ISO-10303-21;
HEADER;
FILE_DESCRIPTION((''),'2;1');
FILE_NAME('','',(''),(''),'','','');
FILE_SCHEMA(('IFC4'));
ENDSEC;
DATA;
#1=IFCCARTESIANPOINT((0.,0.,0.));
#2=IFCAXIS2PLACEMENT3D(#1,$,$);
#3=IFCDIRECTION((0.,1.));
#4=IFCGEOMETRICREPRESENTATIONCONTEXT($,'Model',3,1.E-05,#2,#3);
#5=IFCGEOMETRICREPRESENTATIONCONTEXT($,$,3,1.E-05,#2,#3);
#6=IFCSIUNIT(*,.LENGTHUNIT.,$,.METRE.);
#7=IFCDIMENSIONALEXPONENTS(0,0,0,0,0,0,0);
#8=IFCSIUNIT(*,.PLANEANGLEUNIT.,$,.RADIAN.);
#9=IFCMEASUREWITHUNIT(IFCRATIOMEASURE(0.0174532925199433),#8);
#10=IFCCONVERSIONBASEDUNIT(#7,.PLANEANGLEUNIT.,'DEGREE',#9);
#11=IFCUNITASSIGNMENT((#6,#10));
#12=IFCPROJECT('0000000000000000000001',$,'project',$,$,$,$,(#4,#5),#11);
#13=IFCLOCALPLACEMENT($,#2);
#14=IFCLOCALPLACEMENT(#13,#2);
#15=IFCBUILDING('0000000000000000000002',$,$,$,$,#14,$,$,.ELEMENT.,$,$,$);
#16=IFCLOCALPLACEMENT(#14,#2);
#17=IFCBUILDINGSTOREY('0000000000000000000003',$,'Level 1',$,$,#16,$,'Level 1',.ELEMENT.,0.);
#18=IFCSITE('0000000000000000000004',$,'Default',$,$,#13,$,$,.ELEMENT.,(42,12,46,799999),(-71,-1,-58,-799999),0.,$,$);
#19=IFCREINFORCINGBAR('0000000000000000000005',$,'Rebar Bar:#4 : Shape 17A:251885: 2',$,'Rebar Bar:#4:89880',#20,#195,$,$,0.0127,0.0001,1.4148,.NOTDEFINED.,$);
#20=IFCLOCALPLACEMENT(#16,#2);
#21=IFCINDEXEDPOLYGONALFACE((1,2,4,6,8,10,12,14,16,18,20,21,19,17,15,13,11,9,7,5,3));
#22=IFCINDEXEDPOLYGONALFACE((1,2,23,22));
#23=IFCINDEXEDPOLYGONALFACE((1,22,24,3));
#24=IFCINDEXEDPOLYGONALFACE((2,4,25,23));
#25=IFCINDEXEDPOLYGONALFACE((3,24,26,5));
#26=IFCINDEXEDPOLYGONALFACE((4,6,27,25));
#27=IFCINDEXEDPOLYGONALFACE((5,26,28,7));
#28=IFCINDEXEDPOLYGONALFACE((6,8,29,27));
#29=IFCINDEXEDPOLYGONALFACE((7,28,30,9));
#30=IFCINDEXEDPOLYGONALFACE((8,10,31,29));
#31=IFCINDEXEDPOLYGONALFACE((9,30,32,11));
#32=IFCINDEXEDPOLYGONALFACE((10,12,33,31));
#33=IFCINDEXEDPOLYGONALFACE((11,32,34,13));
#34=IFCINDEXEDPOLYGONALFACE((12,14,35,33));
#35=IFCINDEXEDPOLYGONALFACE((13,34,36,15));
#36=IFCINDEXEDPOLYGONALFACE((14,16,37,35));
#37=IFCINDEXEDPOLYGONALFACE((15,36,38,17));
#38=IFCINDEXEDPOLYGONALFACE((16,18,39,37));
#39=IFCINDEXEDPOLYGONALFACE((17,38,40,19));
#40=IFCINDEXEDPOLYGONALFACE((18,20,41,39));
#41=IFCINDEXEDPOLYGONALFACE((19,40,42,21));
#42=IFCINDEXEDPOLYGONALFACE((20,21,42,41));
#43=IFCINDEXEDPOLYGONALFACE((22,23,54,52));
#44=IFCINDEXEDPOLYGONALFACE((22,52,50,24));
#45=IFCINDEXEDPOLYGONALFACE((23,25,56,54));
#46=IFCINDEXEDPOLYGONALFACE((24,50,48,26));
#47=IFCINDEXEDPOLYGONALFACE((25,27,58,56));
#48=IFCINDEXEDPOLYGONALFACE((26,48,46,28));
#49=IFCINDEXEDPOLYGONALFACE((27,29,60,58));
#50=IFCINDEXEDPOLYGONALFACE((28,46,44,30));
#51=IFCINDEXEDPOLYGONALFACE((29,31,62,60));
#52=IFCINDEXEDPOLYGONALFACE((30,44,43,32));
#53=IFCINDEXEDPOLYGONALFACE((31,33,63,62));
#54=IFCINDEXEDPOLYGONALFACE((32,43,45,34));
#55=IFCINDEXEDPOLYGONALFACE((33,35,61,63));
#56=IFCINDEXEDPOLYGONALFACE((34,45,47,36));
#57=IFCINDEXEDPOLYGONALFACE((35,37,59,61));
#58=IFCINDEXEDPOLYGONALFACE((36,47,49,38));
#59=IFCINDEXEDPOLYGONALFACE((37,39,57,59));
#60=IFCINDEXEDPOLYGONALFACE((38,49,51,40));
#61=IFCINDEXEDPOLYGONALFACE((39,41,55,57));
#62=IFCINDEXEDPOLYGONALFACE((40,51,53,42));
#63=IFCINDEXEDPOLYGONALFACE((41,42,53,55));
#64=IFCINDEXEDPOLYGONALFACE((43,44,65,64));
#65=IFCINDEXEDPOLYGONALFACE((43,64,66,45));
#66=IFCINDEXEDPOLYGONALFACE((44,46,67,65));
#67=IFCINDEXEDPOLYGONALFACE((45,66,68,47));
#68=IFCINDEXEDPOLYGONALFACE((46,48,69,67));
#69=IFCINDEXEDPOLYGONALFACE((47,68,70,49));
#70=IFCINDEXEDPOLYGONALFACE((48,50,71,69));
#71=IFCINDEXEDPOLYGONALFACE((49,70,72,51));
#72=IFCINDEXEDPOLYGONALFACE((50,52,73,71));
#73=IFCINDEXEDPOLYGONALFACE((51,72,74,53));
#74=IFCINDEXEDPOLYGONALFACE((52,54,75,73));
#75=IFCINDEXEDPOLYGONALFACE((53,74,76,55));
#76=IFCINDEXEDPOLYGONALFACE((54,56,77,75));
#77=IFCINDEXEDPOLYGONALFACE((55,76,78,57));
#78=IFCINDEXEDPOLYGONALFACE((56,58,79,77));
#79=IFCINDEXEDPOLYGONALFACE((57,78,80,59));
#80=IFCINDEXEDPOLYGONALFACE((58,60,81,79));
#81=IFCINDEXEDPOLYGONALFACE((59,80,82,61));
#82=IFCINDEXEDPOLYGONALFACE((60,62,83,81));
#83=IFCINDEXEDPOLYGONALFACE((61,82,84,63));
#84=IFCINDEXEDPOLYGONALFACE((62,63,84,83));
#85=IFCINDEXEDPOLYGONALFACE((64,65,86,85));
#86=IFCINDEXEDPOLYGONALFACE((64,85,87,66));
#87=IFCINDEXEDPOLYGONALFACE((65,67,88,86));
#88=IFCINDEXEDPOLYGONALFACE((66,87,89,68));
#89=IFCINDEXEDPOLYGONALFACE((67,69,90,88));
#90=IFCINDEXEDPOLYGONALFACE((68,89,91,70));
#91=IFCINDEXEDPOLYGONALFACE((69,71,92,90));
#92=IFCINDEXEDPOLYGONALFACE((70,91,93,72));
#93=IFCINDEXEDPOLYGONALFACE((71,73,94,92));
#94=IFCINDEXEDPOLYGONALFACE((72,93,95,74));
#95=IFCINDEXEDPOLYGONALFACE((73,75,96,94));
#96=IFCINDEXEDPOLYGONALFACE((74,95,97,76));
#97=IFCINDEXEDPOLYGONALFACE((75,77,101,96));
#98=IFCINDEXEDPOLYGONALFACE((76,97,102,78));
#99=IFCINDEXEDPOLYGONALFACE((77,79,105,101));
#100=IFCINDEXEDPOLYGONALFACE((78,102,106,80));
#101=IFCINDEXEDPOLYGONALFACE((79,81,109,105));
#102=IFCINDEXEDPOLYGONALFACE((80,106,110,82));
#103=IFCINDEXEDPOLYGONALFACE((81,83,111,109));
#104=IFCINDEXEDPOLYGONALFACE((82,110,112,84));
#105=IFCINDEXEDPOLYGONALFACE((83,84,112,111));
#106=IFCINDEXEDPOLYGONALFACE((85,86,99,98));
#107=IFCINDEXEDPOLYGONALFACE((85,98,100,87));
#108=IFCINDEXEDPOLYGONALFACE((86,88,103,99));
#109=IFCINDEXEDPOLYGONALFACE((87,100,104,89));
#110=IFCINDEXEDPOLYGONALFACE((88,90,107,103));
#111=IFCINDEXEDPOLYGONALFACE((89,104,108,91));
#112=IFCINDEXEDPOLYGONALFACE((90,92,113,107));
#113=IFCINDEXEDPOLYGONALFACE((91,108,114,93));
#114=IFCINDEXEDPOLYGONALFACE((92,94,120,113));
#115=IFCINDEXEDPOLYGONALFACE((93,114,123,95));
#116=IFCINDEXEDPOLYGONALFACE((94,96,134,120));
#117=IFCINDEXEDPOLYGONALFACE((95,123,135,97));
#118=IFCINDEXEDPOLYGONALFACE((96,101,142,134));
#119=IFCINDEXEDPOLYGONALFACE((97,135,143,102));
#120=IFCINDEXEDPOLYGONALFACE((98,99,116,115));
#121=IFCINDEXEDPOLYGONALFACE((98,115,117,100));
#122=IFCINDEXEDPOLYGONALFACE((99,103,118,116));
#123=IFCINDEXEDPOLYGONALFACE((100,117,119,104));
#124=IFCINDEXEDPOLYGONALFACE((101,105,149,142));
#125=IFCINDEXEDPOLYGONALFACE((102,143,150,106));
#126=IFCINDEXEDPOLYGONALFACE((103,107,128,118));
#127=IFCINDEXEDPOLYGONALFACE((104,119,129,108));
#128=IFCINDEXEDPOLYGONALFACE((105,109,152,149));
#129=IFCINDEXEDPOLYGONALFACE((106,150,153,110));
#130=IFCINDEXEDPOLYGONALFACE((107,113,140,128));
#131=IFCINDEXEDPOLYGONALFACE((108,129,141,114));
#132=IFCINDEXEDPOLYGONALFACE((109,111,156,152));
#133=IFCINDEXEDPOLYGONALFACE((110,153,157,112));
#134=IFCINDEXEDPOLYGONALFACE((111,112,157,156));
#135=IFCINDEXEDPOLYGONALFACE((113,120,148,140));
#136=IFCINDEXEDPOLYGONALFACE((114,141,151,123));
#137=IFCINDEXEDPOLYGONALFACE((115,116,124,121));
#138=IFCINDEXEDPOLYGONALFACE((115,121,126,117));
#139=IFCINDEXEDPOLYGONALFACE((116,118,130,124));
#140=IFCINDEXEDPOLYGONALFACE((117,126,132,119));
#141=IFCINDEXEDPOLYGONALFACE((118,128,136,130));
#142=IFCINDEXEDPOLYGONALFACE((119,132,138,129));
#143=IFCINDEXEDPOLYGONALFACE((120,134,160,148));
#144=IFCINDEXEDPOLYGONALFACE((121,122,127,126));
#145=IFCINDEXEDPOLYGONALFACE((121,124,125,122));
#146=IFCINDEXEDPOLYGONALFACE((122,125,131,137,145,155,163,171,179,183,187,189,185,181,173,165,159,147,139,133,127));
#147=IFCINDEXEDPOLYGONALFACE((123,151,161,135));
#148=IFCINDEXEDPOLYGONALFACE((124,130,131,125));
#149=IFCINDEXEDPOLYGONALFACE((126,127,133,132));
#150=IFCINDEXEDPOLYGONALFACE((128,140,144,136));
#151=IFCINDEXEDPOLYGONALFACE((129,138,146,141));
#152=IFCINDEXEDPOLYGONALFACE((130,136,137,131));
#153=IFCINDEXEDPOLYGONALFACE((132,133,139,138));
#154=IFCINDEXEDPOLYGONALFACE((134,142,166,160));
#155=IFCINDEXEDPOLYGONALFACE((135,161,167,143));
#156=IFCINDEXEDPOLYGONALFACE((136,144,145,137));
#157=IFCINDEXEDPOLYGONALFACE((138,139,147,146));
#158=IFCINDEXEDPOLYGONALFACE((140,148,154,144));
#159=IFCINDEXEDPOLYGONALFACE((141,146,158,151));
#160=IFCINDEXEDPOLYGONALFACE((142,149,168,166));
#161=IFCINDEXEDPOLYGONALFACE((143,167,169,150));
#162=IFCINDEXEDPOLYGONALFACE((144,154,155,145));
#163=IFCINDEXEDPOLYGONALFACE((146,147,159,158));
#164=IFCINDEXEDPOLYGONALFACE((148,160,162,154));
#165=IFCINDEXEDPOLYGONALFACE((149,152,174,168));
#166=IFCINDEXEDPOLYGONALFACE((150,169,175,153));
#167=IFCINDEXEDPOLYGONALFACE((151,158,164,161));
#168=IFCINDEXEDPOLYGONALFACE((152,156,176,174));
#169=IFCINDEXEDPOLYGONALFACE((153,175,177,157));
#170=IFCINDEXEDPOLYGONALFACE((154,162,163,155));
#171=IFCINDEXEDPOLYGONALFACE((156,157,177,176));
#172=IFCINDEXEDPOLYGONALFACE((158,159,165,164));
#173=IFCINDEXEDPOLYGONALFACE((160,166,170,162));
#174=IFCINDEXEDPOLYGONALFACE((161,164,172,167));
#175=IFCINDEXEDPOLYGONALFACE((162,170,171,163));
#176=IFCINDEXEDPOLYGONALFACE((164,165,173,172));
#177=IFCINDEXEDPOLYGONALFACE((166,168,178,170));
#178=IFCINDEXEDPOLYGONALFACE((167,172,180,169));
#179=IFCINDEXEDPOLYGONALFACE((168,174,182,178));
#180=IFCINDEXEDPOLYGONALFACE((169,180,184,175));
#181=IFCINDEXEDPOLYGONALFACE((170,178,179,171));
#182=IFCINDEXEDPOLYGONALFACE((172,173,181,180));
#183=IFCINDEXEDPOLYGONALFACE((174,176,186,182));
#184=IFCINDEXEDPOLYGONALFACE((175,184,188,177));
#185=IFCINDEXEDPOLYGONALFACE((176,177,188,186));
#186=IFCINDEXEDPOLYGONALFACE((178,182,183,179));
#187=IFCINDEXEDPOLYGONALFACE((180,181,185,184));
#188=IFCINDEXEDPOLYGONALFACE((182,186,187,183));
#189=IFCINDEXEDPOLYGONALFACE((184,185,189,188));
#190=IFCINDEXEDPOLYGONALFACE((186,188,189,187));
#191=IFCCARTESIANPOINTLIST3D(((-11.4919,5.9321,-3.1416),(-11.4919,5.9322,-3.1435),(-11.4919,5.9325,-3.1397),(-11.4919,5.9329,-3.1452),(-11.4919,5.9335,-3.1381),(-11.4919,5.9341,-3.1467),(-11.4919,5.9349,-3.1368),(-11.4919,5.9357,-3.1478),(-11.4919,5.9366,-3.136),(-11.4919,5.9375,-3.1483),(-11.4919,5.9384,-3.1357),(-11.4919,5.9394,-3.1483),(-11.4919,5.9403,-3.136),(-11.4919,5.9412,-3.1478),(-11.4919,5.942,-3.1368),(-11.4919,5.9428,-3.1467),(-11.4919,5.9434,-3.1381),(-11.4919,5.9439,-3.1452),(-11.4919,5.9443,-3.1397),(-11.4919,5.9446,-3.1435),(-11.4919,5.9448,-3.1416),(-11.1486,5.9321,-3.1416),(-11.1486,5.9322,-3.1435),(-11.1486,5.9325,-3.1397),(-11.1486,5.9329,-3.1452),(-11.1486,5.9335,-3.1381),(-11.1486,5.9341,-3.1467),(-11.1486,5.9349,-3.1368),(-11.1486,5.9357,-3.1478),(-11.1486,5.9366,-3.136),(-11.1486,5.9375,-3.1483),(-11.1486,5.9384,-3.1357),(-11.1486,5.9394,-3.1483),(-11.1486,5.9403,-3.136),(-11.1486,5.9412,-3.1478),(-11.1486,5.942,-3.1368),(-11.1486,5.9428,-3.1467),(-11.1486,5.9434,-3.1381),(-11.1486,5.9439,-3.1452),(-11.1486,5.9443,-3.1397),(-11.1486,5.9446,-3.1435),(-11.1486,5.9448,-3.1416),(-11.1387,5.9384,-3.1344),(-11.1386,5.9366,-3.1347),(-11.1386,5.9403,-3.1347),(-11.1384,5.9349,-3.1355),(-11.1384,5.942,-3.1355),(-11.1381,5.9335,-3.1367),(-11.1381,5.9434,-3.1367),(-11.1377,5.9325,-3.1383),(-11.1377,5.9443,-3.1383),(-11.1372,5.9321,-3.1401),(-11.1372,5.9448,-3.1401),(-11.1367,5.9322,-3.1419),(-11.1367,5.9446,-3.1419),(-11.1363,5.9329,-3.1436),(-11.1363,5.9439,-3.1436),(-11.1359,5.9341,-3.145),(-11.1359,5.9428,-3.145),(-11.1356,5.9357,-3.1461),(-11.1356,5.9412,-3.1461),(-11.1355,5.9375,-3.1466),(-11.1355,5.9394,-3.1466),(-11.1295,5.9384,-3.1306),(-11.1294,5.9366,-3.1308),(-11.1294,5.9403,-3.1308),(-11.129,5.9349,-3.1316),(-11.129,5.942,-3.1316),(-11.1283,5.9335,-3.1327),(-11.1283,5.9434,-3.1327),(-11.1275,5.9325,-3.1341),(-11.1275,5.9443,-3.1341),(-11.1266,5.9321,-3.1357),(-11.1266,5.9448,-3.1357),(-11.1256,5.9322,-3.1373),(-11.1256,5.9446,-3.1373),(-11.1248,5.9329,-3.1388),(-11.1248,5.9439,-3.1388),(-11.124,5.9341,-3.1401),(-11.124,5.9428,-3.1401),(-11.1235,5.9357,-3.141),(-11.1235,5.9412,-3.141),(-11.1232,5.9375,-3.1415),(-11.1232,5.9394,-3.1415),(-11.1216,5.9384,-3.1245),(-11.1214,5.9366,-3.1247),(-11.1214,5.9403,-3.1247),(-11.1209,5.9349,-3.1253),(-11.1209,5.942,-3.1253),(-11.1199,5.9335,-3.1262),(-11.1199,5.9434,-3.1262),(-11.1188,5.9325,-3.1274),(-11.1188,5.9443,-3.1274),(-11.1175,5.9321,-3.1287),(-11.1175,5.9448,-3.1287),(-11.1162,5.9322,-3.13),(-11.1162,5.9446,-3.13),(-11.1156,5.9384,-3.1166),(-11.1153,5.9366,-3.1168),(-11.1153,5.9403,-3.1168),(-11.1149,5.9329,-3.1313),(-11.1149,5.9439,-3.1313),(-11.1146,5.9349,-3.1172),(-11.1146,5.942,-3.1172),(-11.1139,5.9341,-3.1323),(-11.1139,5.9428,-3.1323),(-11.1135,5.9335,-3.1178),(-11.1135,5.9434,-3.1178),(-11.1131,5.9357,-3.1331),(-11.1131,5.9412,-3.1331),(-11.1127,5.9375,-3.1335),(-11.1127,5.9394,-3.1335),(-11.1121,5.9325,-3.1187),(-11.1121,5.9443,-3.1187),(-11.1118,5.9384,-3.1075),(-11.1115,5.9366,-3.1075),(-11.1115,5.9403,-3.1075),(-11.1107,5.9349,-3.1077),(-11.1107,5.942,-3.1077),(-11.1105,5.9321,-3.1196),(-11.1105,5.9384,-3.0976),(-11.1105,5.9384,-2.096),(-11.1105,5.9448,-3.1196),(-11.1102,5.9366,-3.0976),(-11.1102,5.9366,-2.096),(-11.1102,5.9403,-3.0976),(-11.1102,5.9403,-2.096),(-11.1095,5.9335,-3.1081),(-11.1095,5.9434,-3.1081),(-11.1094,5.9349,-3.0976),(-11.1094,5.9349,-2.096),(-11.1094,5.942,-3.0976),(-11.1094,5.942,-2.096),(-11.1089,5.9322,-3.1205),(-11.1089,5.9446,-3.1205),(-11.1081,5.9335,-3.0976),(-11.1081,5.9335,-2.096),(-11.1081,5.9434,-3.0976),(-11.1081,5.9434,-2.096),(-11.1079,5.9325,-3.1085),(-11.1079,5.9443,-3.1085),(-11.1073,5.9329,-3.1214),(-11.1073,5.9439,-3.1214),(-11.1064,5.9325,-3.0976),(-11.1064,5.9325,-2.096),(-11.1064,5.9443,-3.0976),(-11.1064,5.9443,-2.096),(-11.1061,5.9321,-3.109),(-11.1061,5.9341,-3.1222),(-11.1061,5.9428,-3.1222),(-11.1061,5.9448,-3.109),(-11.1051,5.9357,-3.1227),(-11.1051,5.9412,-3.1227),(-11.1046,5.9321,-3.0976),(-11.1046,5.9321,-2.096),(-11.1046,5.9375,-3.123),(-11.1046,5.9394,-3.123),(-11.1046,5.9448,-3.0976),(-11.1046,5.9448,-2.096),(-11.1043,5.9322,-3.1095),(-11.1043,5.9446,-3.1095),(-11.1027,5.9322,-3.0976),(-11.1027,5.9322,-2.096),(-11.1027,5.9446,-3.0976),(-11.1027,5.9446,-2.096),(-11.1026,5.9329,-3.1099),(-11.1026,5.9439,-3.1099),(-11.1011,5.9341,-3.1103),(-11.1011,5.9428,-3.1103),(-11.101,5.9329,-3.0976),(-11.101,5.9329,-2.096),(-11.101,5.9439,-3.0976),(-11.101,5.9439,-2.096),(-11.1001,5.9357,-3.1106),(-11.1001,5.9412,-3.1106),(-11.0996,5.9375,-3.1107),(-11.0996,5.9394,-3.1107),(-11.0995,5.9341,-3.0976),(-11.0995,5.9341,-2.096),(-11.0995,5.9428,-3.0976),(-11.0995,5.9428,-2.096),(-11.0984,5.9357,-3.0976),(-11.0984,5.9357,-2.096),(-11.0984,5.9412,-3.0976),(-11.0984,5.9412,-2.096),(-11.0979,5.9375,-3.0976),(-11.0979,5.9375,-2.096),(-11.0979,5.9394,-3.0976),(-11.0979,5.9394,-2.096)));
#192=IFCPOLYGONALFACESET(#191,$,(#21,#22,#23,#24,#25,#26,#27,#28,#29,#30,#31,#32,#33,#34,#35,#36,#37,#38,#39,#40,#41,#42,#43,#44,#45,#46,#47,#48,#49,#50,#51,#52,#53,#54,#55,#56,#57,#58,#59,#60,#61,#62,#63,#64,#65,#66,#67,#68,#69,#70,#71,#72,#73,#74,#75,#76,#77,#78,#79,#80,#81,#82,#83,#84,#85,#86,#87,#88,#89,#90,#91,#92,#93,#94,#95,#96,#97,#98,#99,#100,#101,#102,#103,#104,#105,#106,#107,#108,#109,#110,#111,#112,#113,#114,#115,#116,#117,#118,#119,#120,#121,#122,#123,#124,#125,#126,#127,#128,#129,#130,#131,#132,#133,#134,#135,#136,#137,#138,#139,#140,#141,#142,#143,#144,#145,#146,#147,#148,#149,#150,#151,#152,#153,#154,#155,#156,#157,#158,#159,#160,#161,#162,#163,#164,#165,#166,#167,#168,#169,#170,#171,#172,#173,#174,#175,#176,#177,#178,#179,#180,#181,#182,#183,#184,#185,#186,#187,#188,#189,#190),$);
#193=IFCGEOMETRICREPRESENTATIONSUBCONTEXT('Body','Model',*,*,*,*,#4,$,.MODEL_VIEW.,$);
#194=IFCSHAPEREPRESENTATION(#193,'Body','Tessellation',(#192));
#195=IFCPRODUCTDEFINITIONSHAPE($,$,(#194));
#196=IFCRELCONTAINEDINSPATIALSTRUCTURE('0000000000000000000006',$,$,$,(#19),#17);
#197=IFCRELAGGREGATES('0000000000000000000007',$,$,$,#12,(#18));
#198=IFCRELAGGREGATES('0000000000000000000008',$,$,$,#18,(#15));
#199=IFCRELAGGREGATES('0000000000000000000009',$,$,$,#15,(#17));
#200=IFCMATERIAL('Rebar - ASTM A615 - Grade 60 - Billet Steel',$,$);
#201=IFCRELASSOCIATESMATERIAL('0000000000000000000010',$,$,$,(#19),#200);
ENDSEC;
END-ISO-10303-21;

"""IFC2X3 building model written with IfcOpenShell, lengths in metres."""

from ifc_helpers import new_model, entity, si_unit, converted_unit, direction, origin, place, context, subcontext, project, spatial, material, element, save


model = new_model("IFC2X3")

# Units and contexts
model_context = context("Model", 3, precision=1e-05, world=origin(), true_north=direction((0.0, 1.0)))
context_of_model = context(None, 3, precision=1e-05, world=origin(), true_north=direction((0.0, 1.0)))
body_context = subcontext(model_context, "Body", "Model", "MODEL_VIEW")
ifc_project = project(units=[si_unit("LENGTHUNIT", "METRE"), converted_unit("PLANEANGLEUNIT", "DEGREE", entity("IfcRatioMeasure", 0.0174532925199433), si_unit("PLANEANGLEUNIT", "RADIAN"), dimensions=[0, 0, 0, 0, 0, 0, 0])], contexts=[model_context, context_of_model])

# Site, building, storey
site_placement = place(None, origin())
site = spatial("IfcSite", under=ifc_project, at=site_placement, Name="Default", CompositionType="ELEMENT", RefLatitude=(42, 12, 46, 799999), RefLongitude=(-71, -1, -58, -799999), RefElevation=0.0)
building_placement = place(site_placement, origin())
building = spatial("IfcBuilding", under=site, at=building_placement, CompositionType="ELEMENT")
storey_placement = place(building_placement, origin())
storey = spatial("IfcBuildingStorey", under=building, at=storey_placement, Name="Level 1", LongName="Level 1", CompositionType="ELEMENT", Elevation=0.0)

# Reinforcing bar
ifc_material_1 = material(Name="Rebar - ASTM A615 - Grade 60 - Billet Steel")
reinforcing_bar_1_placement = place(storey_placement, origin())
element("IfcReinforcingBar", 1, at=reinforcing_bar_1_placement, inside=storey, material=ifc_material_1, Name="Rebar Bar:#4 : Shape 17A:251885: 2", ObjectType="Rebar Bar:#4:89880", BarLength=1.4148, BarRole="NOTDEFINED", CrossSectionArea=0.0001, NominalDiameter=0.0127, context=body_context, shape_type="AdvancedSweptSolid", body=[
    entity("IfcSweptDiskSolid", entity("IfcCompositeCurve", [entity("IfcCompositeCurveSegment", "CONTINUOUS", True, entity("IfcPolyline", [entity("IfcCartesianPoint", [-11.4919, 5.9384, -3.142]), entity("IfcCartesianPoint", [-11.1486, 5.9384, -3.142])])), entity("IfcCompositeCurveSegment", "CONTINUOUS", True, entity("IfcTrimmedCurve", entity("IfcCircle", entity("IfcAxis2Placement3D", entity("IfcCartesianPoint", [-11.1486, 5.9384, -3.0976]), entity("IfcDirection", [0.0, -1.0, 0.0]), entity("IfcDirection", [1.0, 0.0, 0.0])), 0.0445), [entity("IfcParameterValue", 270.0)], [entity("IfcParameterValue", 360.0)], True, "PARAMETER")), entity("IfcCompositeCurveSegment", "CONTINUOUS", True, entity("IfcPolyline", [entity("IfcCartesianPoint", [-11.1041, 5.9384, -3.0976]), entity("IfcCartesianPoint", [-11.1041, 5.9384, -2.096])]))], False), 0.0063, None, 0.0, 92.0),
])

save(model, "model.ifc")
